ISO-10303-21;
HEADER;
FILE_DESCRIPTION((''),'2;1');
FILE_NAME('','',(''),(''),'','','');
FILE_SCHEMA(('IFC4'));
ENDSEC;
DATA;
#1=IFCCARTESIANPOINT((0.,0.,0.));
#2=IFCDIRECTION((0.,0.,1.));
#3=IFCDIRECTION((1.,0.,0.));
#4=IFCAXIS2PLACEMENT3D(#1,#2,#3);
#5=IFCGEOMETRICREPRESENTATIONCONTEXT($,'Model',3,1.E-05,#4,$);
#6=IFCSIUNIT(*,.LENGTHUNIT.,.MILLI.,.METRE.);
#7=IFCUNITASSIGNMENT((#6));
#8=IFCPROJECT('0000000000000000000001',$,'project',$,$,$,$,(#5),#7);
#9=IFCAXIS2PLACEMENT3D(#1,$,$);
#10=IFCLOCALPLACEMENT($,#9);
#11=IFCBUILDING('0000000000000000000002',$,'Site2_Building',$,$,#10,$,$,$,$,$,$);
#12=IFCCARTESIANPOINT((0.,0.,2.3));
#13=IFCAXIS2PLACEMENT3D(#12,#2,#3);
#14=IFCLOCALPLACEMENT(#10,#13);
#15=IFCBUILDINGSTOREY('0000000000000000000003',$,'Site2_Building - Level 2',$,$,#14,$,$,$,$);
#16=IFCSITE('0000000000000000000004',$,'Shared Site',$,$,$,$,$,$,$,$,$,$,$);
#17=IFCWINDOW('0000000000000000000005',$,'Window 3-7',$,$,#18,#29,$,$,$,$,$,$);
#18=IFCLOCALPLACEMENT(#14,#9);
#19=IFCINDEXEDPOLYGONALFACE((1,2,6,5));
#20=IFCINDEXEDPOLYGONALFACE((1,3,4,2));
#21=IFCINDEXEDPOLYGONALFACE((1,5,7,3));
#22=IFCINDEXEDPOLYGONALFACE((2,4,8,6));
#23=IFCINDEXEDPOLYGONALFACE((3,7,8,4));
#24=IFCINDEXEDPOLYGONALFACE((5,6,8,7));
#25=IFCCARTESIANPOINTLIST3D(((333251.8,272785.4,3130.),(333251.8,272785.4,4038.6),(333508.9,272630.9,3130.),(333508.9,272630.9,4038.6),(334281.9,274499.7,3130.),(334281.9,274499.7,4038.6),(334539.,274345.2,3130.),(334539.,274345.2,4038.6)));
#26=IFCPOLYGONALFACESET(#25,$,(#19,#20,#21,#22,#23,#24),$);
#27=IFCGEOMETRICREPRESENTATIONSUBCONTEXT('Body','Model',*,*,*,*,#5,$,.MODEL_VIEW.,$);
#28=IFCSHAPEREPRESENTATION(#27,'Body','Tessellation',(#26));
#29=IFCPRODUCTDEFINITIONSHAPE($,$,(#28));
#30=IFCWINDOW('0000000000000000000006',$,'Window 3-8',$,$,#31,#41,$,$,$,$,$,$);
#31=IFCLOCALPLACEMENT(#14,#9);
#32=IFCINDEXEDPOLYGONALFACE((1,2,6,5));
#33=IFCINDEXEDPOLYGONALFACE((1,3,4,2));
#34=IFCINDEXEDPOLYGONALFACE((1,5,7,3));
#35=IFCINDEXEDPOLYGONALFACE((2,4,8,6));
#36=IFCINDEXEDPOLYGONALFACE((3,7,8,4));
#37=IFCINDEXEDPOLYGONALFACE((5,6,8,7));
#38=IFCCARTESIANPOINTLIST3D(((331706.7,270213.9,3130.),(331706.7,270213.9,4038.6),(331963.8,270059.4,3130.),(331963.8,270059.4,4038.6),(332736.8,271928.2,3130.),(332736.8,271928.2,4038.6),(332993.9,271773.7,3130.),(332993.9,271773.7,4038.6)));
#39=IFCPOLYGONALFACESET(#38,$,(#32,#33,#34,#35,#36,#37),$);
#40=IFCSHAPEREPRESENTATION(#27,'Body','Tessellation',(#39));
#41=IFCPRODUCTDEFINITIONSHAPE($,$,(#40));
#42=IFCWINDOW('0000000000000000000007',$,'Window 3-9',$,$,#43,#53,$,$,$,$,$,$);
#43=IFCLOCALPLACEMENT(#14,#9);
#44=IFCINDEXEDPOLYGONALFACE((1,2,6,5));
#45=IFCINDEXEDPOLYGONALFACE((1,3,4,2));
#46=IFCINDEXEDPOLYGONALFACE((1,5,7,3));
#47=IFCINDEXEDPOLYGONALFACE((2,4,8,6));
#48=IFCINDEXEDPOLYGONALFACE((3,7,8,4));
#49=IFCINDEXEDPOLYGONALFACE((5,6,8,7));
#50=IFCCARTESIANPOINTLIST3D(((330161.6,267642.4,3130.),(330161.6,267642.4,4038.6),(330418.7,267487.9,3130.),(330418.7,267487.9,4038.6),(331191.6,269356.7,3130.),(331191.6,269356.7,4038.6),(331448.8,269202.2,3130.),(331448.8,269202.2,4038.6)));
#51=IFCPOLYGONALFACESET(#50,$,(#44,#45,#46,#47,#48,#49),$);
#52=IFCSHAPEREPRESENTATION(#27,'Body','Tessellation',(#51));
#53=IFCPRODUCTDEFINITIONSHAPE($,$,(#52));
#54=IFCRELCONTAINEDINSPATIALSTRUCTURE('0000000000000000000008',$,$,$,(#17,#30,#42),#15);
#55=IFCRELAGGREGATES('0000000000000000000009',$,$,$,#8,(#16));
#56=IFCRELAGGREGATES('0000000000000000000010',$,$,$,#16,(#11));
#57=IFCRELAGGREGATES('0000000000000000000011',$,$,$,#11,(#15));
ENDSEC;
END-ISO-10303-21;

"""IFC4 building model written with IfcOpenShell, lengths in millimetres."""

from ifc_helpers import new_model, si_unit, frame, origin, origin_with_axes, place, context, subcontext, project, spatial, indexed_curve, outline, extrude, element, save


model = new_model("IFC4")

# Units and contexts
model_context = context("Model", 3, precision=1e-05, world=origin_with_axes())
body_context = subcontext(model_context, "Body", "Model", "MODEL_VIEW")
ifc_project = project(units=[si_unit("LENGTHUNIT", "METRE", prefix="MILLI")], contexts=[model_context])

# Site, building, storey
site = spatial("IfcSite", under=ifc_project, Name="Shared Site")
building_placement = place(None, origin())
building = spatial("IfcBuilding", under=site, at=building_placement, Name="Site2_Building")
storey_placement = place(building_placement, frame((0.0, 0.0, 2.3), z_axis=(0.0, 0.0, 1.0), x_axis=(1.0, 0.0, 0.0)))
storey = spatial("IfcBuildingStorey", under=building, at=storey_placement, Name="Site2_Building - Level 2")

# Windows
for number, where, z_axis, x_axis, name in (
    (1, (334281.9, 274499.7, 3130.0), (0.0, 0.0, 1.0), (-0.515038, -0.857167, 0.0), "Window 3-7"),
    (2, (332736.8, 271928.2, 3130.0), (0.0, 0.0, 1.0), (-0.515038, -0.857167, 0.0), "Window 3-8"),
    (3, (331191.6, 269356.7, 3130.0), (0.0, 0.0, 1.0), (-0.515038, -0.857167, 0.0), "Window 3-9"),
):
    element("IfcWindow", number, at=place(storey_placement, frame(where, z_axis=z_axis, x_axis=x_axis)), inside=storey, Name=name, context=body_context, shape_type="SweptSolid", body=[
        extrude(outline(indexed_curve([(0.0, 0.0), (0.0, 300.0), (2000.0, 300.0), (2000.0, 0.0), (0.0, 0.0)], self_intersect=False)), origin_with_axes(), (0.0, 0.0, 1.0), 908.6),
    ])

save(model, "model.ifc")
